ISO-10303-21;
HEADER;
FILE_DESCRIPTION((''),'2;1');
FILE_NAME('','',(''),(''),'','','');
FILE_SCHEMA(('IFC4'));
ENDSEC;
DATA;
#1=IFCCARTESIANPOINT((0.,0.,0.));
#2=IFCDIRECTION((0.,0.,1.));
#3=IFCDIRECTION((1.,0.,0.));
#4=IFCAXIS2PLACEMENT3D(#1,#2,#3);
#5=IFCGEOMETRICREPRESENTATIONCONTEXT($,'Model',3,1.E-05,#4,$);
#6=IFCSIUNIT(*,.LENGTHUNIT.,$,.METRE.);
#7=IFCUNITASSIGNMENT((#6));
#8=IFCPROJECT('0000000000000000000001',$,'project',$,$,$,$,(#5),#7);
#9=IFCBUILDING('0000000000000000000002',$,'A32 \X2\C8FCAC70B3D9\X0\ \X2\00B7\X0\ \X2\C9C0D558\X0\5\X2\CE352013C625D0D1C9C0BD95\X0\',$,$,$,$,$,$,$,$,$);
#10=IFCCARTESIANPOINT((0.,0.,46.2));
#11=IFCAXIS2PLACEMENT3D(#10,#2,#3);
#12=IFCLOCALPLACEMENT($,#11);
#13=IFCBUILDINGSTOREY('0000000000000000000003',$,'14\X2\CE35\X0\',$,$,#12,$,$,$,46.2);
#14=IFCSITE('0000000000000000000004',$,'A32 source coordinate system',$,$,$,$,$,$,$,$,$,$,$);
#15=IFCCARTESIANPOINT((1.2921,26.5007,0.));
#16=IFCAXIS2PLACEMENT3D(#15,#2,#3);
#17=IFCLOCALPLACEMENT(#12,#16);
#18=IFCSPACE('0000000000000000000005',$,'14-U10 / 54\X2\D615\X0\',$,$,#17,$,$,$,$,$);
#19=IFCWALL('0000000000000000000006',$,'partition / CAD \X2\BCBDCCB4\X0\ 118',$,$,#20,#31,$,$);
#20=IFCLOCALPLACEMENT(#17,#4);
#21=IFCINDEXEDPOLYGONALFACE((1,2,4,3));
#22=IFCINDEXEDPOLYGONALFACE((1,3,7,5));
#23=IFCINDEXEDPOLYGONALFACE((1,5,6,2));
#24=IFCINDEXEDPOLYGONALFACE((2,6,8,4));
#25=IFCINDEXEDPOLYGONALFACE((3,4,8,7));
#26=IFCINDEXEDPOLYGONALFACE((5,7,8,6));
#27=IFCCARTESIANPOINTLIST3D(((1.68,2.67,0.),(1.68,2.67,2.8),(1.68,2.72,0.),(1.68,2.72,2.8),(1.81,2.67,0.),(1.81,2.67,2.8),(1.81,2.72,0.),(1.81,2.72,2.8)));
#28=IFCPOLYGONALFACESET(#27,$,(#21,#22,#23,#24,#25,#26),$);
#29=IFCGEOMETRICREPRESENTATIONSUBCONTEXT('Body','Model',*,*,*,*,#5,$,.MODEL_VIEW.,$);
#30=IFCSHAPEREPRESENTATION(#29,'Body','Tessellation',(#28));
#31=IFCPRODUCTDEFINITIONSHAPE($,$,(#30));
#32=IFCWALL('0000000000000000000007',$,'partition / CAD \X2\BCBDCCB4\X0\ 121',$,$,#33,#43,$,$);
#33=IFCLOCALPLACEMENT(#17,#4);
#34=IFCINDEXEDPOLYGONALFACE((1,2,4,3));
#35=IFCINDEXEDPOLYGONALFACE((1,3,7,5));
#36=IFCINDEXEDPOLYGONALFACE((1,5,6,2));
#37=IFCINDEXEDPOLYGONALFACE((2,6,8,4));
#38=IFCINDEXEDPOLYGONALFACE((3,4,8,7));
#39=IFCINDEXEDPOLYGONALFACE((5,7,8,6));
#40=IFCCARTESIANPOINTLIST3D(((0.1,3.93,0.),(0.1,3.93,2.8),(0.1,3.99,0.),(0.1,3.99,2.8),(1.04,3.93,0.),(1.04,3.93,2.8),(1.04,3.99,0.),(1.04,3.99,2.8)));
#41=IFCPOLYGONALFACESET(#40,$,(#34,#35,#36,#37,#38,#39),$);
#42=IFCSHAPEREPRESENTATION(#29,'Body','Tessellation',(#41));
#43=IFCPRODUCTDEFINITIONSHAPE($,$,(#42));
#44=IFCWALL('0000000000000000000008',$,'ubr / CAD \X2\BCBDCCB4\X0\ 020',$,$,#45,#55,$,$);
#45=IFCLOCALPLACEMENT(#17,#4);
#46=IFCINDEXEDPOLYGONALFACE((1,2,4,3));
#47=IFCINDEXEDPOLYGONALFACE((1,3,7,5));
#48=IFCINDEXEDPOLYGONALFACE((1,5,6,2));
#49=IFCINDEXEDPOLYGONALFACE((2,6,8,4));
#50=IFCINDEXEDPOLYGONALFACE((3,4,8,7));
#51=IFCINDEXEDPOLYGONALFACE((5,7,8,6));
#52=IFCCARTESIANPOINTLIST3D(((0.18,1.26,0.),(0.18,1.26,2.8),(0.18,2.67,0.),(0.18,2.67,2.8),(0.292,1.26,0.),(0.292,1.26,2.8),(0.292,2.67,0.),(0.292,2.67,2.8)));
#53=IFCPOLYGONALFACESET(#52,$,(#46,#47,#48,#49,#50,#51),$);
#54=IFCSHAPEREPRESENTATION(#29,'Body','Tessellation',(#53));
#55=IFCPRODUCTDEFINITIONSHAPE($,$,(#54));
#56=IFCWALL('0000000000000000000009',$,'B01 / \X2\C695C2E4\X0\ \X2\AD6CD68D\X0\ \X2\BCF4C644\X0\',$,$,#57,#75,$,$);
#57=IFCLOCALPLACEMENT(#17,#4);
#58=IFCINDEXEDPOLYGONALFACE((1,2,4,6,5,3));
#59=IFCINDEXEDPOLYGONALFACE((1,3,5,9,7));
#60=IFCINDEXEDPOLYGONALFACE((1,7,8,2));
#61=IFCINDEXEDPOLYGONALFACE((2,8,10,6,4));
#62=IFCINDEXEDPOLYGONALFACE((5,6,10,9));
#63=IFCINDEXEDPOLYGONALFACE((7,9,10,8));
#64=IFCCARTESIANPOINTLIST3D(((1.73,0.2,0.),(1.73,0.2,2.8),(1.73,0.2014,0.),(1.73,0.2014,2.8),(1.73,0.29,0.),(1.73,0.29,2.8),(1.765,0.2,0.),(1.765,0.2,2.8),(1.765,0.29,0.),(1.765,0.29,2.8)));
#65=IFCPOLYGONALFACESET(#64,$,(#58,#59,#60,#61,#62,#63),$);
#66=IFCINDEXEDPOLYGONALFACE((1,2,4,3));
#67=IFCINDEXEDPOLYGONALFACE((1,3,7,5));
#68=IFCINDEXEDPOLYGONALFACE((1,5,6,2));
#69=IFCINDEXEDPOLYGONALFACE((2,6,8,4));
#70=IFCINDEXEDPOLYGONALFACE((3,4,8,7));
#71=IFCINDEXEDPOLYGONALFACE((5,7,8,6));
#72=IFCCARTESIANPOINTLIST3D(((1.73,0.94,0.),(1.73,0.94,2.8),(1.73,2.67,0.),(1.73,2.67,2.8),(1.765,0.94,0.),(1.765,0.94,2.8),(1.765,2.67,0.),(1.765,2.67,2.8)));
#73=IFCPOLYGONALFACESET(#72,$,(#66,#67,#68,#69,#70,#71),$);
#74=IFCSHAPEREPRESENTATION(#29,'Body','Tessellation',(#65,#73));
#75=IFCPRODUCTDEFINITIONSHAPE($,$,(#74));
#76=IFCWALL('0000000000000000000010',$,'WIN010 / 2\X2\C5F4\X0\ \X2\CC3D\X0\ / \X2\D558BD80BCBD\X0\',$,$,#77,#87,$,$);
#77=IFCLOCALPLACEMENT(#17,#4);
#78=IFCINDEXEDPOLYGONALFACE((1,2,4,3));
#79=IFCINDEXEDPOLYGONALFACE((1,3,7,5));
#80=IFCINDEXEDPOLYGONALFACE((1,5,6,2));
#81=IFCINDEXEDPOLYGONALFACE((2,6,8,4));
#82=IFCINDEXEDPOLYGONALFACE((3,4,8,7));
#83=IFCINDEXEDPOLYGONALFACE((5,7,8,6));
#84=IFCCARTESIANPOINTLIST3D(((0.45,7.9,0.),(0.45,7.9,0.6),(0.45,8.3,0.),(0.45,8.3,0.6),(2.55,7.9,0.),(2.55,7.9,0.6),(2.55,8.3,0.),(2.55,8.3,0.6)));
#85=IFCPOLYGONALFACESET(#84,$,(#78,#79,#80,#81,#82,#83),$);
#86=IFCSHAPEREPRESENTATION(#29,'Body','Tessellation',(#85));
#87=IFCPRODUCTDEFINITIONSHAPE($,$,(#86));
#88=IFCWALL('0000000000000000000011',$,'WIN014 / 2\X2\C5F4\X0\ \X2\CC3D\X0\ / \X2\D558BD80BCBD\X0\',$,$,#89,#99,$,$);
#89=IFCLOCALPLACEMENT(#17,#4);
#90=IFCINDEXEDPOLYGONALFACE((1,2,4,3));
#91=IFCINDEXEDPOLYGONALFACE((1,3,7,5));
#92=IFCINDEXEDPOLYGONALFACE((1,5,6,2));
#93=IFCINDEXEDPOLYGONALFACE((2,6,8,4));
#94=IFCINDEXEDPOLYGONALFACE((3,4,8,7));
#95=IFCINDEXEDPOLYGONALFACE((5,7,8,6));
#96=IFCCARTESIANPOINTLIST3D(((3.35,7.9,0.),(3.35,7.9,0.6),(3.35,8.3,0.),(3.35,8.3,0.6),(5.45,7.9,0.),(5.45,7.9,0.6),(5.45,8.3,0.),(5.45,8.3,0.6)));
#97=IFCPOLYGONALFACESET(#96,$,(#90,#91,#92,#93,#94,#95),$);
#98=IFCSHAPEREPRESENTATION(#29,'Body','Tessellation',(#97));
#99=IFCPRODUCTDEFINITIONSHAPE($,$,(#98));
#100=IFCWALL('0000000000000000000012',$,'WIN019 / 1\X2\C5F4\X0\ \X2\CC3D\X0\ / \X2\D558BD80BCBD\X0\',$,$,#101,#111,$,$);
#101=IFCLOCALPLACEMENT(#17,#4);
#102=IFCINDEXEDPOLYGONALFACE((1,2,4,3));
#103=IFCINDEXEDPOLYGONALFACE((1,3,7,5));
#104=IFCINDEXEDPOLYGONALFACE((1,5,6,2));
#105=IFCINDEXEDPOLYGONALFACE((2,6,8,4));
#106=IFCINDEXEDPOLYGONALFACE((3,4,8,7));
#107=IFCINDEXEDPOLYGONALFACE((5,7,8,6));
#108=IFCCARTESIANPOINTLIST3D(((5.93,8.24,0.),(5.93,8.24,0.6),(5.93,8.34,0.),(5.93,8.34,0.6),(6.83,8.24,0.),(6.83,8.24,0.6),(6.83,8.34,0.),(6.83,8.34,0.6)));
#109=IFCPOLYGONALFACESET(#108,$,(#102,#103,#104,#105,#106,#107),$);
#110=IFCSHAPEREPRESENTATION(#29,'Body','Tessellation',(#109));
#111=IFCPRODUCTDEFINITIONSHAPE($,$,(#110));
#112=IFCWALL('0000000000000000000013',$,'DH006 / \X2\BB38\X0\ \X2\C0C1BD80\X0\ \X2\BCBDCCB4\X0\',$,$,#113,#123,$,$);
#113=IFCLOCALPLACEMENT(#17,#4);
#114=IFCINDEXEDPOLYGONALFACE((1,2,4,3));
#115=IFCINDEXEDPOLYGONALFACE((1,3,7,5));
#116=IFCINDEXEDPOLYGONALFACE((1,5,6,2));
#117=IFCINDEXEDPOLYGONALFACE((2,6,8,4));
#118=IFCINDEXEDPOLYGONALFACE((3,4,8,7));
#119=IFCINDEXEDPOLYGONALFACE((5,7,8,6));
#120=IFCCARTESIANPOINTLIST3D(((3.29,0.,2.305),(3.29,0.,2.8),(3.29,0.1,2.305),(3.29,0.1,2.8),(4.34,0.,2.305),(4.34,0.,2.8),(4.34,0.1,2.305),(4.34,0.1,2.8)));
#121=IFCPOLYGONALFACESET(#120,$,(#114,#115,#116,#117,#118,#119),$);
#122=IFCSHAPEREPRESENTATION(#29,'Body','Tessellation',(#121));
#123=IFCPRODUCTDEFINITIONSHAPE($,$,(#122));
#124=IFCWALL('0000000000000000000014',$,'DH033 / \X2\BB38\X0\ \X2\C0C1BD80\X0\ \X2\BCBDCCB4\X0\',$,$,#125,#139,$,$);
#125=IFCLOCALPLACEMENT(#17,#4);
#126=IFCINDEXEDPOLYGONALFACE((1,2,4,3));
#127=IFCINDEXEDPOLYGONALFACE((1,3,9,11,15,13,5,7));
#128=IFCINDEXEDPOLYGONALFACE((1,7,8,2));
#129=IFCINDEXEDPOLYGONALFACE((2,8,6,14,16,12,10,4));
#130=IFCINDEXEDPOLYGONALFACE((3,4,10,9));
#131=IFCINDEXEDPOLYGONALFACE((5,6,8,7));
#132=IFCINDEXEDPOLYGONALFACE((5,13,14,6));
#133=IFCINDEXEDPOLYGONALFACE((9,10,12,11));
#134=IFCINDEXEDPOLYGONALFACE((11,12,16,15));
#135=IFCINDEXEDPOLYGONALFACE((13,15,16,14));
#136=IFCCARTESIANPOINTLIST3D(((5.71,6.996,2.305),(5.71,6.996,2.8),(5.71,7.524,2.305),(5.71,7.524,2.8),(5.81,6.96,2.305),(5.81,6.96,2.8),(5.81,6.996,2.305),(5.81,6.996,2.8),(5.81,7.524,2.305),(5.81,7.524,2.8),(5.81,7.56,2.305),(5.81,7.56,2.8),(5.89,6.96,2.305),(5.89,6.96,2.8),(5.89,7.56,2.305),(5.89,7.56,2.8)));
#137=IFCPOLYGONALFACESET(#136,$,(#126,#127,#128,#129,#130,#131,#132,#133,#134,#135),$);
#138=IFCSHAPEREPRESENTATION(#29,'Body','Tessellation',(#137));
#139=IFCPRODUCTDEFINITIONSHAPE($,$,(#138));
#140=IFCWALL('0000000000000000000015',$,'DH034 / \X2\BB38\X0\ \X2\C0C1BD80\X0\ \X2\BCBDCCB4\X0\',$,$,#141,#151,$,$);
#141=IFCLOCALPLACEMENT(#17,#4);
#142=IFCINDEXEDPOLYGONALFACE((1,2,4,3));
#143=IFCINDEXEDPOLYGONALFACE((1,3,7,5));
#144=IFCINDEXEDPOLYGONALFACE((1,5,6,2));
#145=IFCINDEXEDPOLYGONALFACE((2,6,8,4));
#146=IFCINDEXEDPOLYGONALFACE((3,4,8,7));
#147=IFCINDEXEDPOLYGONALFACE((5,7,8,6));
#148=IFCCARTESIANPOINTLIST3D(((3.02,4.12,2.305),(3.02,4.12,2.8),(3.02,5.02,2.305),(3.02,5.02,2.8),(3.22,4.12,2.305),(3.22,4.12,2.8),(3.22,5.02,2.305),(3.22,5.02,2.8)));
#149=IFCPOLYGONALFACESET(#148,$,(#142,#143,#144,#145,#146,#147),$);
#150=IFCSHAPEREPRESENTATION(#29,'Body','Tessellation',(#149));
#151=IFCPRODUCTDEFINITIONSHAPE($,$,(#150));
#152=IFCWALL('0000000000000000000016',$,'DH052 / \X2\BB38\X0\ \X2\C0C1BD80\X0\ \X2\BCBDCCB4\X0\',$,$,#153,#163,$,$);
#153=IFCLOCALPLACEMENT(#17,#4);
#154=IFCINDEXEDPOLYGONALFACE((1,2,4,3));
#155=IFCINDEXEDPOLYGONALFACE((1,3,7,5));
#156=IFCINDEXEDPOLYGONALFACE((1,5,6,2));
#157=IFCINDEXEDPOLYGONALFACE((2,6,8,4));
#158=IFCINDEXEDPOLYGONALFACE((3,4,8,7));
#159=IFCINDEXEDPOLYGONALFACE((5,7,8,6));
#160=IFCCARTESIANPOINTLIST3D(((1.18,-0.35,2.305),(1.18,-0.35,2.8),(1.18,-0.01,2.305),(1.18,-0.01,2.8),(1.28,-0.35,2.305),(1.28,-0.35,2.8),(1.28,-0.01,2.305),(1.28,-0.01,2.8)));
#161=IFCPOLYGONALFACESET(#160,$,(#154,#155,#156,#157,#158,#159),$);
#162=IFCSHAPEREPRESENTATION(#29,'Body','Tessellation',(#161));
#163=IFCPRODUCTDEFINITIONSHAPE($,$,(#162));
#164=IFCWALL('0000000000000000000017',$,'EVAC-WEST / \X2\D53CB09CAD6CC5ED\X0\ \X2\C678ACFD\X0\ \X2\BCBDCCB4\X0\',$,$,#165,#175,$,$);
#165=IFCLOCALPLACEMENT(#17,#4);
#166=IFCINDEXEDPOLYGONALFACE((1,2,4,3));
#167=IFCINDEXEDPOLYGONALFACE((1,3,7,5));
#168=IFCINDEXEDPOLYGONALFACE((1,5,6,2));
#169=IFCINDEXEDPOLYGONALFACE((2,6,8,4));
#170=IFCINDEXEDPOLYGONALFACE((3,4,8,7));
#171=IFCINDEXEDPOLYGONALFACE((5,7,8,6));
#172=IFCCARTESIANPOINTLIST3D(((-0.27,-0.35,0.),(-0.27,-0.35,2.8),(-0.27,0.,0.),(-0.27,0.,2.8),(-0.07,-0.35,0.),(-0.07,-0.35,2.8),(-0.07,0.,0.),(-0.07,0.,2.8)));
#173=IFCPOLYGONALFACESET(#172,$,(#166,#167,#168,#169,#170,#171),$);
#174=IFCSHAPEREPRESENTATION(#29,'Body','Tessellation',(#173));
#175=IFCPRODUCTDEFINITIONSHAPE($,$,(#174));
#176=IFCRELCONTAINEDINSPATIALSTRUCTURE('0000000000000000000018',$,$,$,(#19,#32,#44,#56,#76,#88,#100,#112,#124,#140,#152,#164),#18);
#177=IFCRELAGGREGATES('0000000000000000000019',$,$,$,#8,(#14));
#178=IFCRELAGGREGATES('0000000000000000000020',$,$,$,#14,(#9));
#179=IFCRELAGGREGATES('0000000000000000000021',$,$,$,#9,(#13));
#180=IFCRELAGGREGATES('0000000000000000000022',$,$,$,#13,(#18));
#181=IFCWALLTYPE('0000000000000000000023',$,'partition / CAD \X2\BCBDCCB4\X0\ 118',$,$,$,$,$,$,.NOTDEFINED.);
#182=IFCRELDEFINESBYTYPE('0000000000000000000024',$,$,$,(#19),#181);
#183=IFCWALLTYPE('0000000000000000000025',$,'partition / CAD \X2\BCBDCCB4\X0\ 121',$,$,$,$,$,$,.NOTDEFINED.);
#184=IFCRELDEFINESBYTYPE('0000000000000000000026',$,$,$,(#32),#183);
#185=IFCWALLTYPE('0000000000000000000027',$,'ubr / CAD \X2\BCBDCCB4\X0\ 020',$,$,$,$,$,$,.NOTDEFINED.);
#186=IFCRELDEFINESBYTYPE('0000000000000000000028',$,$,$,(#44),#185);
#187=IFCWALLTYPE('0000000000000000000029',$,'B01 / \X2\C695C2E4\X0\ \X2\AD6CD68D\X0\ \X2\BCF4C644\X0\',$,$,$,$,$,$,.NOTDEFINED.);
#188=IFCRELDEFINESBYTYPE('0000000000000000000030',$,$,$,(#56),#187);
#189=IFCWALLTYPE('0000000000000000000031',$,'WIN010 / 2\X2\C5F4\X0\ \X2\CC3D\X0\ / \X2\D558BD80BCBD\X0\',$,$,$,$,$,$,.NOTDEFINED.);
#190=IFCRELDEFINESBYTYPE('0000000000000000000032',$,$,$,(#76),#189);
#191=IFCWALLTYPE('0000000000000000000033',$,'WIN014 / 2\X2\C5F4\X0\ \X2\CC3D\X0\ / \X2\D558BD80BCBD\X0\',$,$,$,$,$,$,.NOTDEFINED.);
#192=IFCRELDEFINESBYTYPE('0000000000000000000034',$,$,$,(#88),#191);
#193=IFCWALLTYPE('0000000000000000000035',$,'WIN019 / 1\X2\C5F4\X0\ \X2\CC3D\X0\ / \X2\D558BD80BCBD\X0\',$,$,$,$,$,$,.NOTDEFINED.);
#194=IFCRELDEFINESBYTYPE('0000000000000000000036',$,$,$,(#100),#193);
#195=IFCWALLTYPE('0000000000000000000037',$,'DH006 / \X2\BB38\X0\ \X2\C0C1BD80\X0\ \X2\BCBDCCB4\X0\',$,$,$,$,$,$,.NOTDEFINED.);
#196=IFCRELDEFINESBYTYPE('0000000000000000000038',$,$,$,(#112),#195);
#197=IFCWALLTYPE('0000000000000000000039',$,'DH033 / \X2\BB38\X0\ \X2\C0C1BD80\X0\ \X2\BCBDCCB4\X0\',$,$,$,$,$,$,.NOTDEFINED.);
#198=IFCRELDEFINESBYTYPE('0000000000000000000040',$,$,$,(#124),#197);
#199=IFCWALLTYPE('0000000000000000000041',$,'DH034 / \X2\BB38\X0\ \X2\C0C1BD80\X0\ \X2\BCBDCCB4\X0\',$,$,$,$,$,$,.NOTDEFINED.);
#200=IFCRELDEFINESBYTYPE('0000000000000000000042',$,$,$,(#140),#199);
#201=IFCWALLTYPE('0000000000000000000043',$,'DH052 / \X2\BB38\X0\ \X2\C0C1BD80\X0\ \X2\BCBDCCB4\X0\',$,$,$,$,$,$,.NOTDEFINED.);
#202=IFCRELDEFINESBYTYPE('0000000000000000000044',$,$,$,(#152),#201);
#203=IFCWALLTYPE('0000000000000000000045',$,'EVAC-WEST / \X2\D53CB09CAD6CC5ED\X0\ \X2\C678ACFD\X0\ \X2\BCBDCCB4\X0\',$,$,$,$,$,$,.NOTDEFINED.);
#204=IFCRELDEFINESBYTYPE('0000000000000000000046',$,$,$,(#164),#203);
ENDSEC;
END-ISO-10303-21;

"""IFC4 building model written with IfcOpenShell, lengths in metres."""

from ifc_helpers import new_model, si_unit, frame, origin, origin_with_axes, place, context, subcontext, project, spatial, polyline, outline, extrude, source, transform, mapped, type_object, type_shapes, element, save


model = new_model("IFC4")

# Units and contexts
model_context = context("Model", 3, precision=1e-05, world=origin_with_axes())
body_context = subcontext(model_context, "Body", "Model", "MODEL_VIEW")
ifc_project = project(units=[si_unit("LENGTHUNIT", "METRE")], contexts=[model_context])

# Site, building, storey, space
site = spatial("IfcSite", under=ifc_project, Name="A32 source coordinate system")
building = spatial("IfcBuilding", under=site, Name="A32 주거동 · 지하5층–옥탑지붕")
storey_placement = place(None, frame((0.0, 0.0, 46.2), z_axis=(0.0, 0.0, 1.0), x_axis=(1.0, 0.0, 0.0)))
storey = spatial("IfcBuildingStorey", under=building, at=storey_placement, Name="14층", Elevation=46.2)
space_placement = place(storey_placement, frame((1.2921, 26.5007, 0.0), z_axis=(0.0, 0.0, 1.0), x_axis=(1.0, 0.0, 0.0)))
space = spatial("IfcSpace", under=storey, at=space_placement, Name="14-U10 / 54형")

# Walls
wall_type_1 = type_object("IfcWallType", Name="partition / CAD 벽체 118", PredefinedType="NOTDEFINED")
shared_shape_1 = source(origin(), body_context, "Body", "SweptSolid", [
    extrude(outline(polyline([(1.81, 2.67), (1.68, 2.67), (1.68, 2.72), (1.81, 2.72), (1.81, 2.67)])), origin(), (0.0, 0.0, 1.0), 2.8),
])
type_shapes(wall_type_1, [shared_shape_1])
wall_1_placement = place(space_placement, origin_with_axes())
element("IfcWall", 1, at=wall_1_placement, inside=space, type_object=wall_type_1, Name="partition / CAD 벽체 118", context=body_context, shape_type="MappedRepresentation", body=[
    mapped(shared_shape_1, transform((0.0, 0.0, 0.0), scale=1.0)),
])
wall_type_2 = type_object("IfcWallType", Name="partition / CAD 벽체 121", PredefinedType="NOTDEFINED")
shared_shape_2 = source(origin(), body_context, "Body", "SweptSolid", [
    extrude(outline(polyline([(0.1, 3.99), (1.04, 3.99), (1.04, 3.93), (0.1, 3.93), (0.1, 3.99)])), origin(), (0.0, 0.0, 1.0), 2.8),
])
type_shapes(wall_type_2, [shared_shape_2])
wall_2_placement = place(space_placement, origin_with_axes())
element("IfcWall", 2, at=wall_2_placement, inside=space, type_object=wall_type_2, Name="partition / CAD 벽체 121", context=body_context, shape_type="MappedRepresentation", body=[
    mapped(shared_shape_2, transform((0.0, 0.0, 0.0), scale=1.0)),
])
wall_type_3 = type_object("IfcWallType", Name="ubr / CAD 벽체 020", PredefinedType="NOTDEFINED")
shared_shape_3 = source(origin(), body_context, "Body", "SweptSolid", [
    extrude(outline(polyline([(0.18, 1.26), (0.18, 2.67), (0.292, 2.67), (0.292, 1.26), (0.18, 1.26)])), origin(), (0.0, 0.0, 1.0), 2.8),
])
type_shapes(wall_type_3, [shared_shape_3])
wall_3_placement = place(space_placement, origin_with_axes())
element("IfcWall", 3, at=wall_3_placement, inside=space, type_object=wall_type_3, Name="ubr / CAD 벽체 020", context=body_context, shape_type="MappedRepresentation", body=[
    mapped(shared_shape_3, transform((0.0, 0.0, 0.0), scale=1.0)),
])
wall_type_4 = type_object("IfcWallType", Name="B01 / 욕실 구획 보완", PredefinedType="NOTDEFINED")
shared_shape_4 = source(origin(), body_context, "Body", "SweptSolid", [
    extrude(outline(polyline([(1.765, 0.2), (1.73, 0.2), (1.73, 0.2014), (1.73, 0.29), (1.765, 0.29), (1.765, 0.2)])), origin(), (0.0, 0.0, 1.0), 2.8),
    extrude(outline(polyline([(1.765, 2.67), (1.765, 0.94), (1.73, 0.94), (1.73, 2.67), (1.765, 2.67)])), origin(), (0.0, 0.0, 1.0), 2.8),
])
type_shapes(wall_type_4, [shared_shape_4])
wall_4_placement = place(space_placement, origin_with_axes())
element("IfcWall", 4, at=wall_4_placement, inside=space, type_object=wall_type_4, Name="B01 / 욕실 구획 보완", context=body_context, shape_type="MappedRepresentation", body=[
    mapped(shared_shape_4, transform((0.0, 0.0, 0.0), scale=1.0)),
])
wall_type_5 = type_object("IfcWallType", Name="WIN010 / 2열 창 / 하부벽", PredefinedType="NOTDEFINED")
shared_shape_5 = source(origin(), body_context, "Body", "SweptSolid", [
    extrude(outline(polyline([(2.55, 8.3), (2.55, 7.9), (0.45, 7.9), (0.45, 8.3), (2.55, 8.3)])), origin(), (0.0, 0.0, 1.0), 0.6),
])
type_shapes(wall_type_5, [shared_shape_5])
wall_5_placement = place(space_placement, origin_with_axes())
element("IfcWall", 5, at=wall_5_placement, inside=space, type_object=wall_type_5, Name="WIN010 / 2열 창 / 하부벽", context=body_context, shape_type="MappedRepresentation", body=[
    mapped(shared_shape_5, transform((0.0, 0.0, 0.0), scale=1.0)),
])
wall_type_6 = type_object("IfcWallType", Name="WIN014 / 2열 창 / 하부벽", PredefinedType="NOTDEFINED")
shared_shape_6 = source(origin(), body_context, "Body", "SweptSolid", [
    extrude(outline(polyline([(5.45, 8.3), (5.45, 7.9), (3.35, 7.9), (3.35, 8.3), (5.45, 8.3)])), origin(), (0.0, 0.0, 1.0), 0.6),
])
type_shapes(wall_type_6, [shared_shape_6])
wall_6_placement = place(space_placement, origin_with_axes())
element("IfcWall", 6, at=wall_6_placement, inside=space, type_object=wall_type_6, Name="WIN014 / 2열 창 / 하부벽", context=body_context, shape_type="MappedRepresentation", body=[
    mapped(shared_shape_6, transform((0.0, 0.0, 0.0), scale=1.0)),
])
wall_type_7 = type_object("IfcWallType", Name="WIN019 / 1열 창 / 하부벽", PredefinedType="NOTDEFINED")
shared_shape_7 = source(origin(), body_context, "Body", "SweptSolid", [
    extrude(outline(polyline([(6.83, 8.34), (6.83, 8.24), (5.93, 8.24), (5.93, 8.34), (6.83, 8.34)])), origin(), (0.0, 0.0, 1.0), 0.6),
])
type_shapes(wall_type_7, [shared_shape_7])
wall_7_placement = place(space_placement, origin_with_axes())
element("IfcWall", 7, at=wall_7_placement, inside=space, type_object=wall_type_7, Name="WIN019 / 1열 창 / 하부벽", context=body_context, shape_type="MappedRepresentation", body=[
    mapped(shared_shape_7, transform((0.0, 0.0, 0.0), scale=1.0)),
])
wall_type_8 = type_object("IfcWallType", Name="DH006 / 문 상부 벽체", PredefinedType="NOTDEFINED")
shared_shape_8 = source(origin(), body_context, "Body", "SweptSolid", [
    extrude(outline(polyline([(4.34, 0.0), (3.29, 0.0), (3.29, 0.1), (4.34, 0.1), (4.34, 0.0)])), frame((0.0, 0.0, 2.305)), (0.0, 0.0, 1.0), 0.495),
])
type_shapes(wall_type_8, [shared_shape_8])
wall_8_placement = place(space_placement, origin_with_axes())
element("IfcWall", 8, at=wall_8_placement, inside=space, type_object=wall_type_8, Name="DH006 / 문 상부 벽체", context=body_context, shape_type="MappedRepresentation", body=[
    mapped(shared_shape_8, transform((0.0, 0.0, 0.0), scale=1.0)),
])
wall_type_9 = type_object("IfcWallType", Name="DH033 / 문 상부 벽체", PredefinedType="NOTDEFINED")
shared_shape_9 = source(origin(), body_context, "Body", "SweptSolid", [
    extrude(outline(polyline([(5.81, 6.996), (5.71, 6.996), (5.71, 7.524), (5.81, 7.524), (5.81, 7.56), (5.89, 7.56), (5.89, 6.96), (5.81, 6.96), (5.81, 6.996)])), frame((0.0, 0.0, 2.305)), (0.0, 0.0, 1.0), 0.495),
])
type_shapes(wall_type_9, [shared_shape_9])
wall_9_placement = place(space_placement, origin_with_axes())
element("IfcWall", 9, at=wall_9_placement, inside=space, type_object=wall_type_9, Name="DH033 / 문 상부 벽체", context=body_context, shape_type="MappedRepresentation", body=[
    mapped(shared_shape_9, transform((0.0, 0.0, 0.0), scale=1.0)),
])
wall_type_10 = type_object("IfcWallType", Name="DH034 / 문 상부 벽체", PredefinedType="NOTDEFINED")
shared_shape_10 = source(origin(), body_context, "Body", "SweptSolid", [
    extrude(outline(polyline([(3.22, 4.12), (3.02, 4.12), (3.02, 5.02), (3.22, 5.02), (3.22, 4.12)])), frame((0.0, 0.0, 2.305)), (0.0, 0.0, 1.0), 0.495),
])
type_shapes(wall_type_10, [shared_shape_10])
wall_10_placement = place(space_placement, origin_with_axes())
element("IfcWall", 10, at=wall_10_placement, inside=space, type_object=wall_type_10, Name="DH034 / 문 상부 벽체", context=body_context, shape_type="MappedRepresentation", body=[
    mapped(shared_shape_10, transform((0.0, 0.0, 0.0), scale=1.0)),
])
wall_type_11 = type_object("IfcWallType", Name="DH052 / 문 상부 벽체", PredefinedType="NOTDEFINED")
shared_shape_11 = source(origin(), body_context, "Body", "SweptSolid", [
    extrude(outline(polyline([(1.28, -0.35), (1.18, -0.35), (1.18, -0.01), (1.28, -0.01), (1.28, -0.35)])), frame((0.0, 0.0, 2.305)), (0.0, 0.0, 1.0), 0.495),
])
type_shapes(wall_type_11, [shared_shape_11])
wall_11_placement = place(space_placement, origin_with_axes())
element("IfcWall", 11, at=wall_11_placement, inside=space, type_object=wall_type_11, Name="DH052 / 문 상부 벽체", context=body_context, shape_type="MappedRepresentation", body=[
    mapped(shared_shape_11, transform((0.0, 0.0, 0.0), scale=1.0)),
])
wall_type_12 = type_object("IfcWallType", Name="EVAC-WEST / 피난구역 외곽 벽체", PredefinedType="NOTDEFINED")
shared_shape_12 = source(origin(), body_context, "Body", "SweptSolid", [
    extrude(outline(polyline([(-0.07, 0.0), (-0.07, -0.35), (-0.27, -0.35), (-0.27, 0.0), (-0.07, 0.0)])), origin(), (0.0, 0.0, 1.0), 2.8),
])
type_shapes(wall_type_12, [shared_shape_12])
wall_12_placement = place(space_placement, origin_with_axes())
element("IfcWall", 12, at=wall_12_placement, inside=space, type_object=wall_type_12, Name="EVAC-WEST / 피난구역 외곽 벽체", context=body_context, shape_type="MappedRepresentation", body=[
    mapped(shared_shape_12, transform((0.0, 0.0, 0.0), scale=1.0)),
])

save(model, "model.ifc")
